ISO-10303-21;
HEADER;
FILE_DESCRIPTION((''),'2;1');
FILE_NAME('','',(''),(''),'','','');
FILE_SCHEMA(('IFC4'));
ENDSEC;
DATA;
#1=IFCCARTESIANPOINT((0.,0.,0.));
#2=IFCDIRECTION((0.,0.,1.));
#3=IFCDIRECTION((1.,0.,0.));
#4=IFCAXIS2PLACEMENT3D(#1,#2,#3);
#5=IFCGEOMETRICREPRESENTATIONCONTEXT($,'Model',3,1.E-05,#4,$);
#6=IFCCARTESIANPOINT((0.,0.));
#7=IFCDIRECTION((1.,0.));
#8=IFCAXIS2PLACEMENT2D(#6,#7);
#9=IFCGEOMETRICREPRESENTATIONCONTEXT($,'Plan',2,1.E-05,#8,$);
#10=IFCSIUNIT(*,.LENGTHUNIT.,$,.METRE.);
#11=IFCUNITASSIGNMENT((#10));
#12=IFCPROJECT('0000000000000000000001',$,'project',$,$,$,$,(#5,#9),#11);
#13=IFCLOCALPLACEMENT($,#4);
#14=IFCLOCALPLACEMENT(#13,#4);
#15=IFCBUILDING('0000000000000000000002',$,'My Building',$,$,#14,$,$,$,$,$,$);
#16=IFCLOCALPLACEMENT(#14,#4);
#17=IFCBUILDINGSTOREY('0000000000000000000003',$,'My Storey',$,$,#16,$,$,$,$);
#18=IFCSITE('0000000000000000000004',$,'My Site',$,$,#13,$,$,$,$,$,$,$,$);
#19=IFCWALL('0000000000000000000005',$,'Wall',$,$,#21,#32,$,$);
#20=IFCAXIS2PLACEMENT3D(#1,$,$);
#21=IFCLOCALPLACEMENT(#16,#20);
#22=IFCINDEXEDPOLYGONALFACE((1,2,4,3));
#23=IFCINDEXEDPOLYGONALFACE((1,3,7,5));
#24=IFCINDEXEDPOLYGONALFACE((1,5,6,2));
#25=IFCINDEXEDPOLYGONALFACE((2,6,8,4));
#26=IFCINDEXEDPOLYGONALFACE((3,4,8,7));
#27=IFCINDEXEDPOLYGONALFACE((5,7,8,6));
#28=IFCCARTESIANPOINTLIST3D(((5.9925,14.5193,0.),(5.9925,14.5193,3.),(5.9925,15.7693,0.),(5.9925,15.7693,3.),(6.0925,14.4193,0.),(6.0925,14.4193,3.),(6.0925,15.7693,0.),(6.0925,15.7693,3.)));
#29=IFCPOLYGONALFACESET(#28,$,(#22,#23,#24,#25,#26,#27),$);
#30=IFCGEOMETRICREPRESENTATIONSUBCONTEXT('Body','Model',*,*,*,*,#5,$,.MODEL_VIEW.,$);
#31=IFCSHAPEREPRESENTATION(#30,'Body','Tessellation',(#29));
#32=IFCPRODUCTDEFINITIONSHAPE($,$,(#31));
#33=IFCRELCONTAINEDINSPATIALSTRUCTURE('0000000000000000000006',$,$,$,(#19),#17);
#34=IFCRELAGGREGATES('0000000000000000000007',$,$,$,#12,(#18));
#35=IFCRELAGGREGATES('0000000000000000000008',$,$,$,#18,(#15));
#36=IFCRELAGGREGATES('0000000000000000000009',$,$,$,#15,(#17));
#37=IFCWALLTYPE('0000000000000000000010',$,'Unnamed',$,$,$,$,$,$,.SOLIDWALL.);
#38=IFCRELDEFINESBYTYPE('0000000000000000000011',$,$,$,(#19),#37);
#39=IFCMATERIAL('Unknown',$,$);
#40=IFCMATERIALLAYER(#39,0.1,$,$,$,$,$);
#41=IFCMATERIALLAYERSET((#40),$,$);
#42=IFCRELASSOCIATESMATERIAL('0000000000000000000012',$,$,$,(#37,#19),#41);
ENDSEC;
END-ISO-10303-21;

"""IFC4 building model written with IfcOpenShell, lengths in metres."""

from ifc_helpers import new_model, si_unit, frame, origin_with_axes, origin_2d_with_axis, place, context, subcontext, project, spatial, line, indexed_curve, outline, extrude, material, layer, layer_set, layer_usage, type_object, element, save


model = new_model("IFC4")

# Units and contexts
model_context = context("Model", 3, precision=1e-05, world=origin_with_axes())
plan_context = context("Plan", 2, precision=1e-05, world=origin_2d_with_axis())
body_context = subcontext(model_context, "Body", "Model", "MODEL_VIEW")
ifc_project = project(units=[si_unit("LENGTHUNIT", "METRE")], contexts=[model_context, plan_context])

# Site, building, storey
site_placement = place(None, origin_with_axes())
site = spatial("IfcSite", under=ifc_project, at=site_placement, Name="My Site")
building_placement = place(site_placement, origin_with_axes())
building = spatial("IfcBuilding", under=site, at=building_placement, Name="My Building")
storey_placement = place(building_placement, origin_with_axes())
storey = spatial("IfcBuildingStorey", under=building, at=storey_placement, Name="My Storey")

# Shared definitions
ifc_material = material(Name="Unknown")

# Wall
ifc_layer_1 = layer(ifc_material, 0.1)
ifc_layer_set_1 = layer_set([ifc_layer_1])
wall_type = type_object("IfcWallType", Name="Unnamed", PredefinedType="SOLIDWALL", material=ifc_layer_set_1)
ifc_layer_usage_1 = layer_usage(ifc_layer_set_1, "AXIS2", "POSITIVE", 0.0)
wall_1_placement = place(storey_placement, frame((6.0925, 14.5193, 0.0), z_axis=(0.0, 0.0, 1.0), x_axis=(0.0, 1.0, 0.0)))
element("IfcWall", 1, at=wall_1_placement, inside=storey, type_object=wall_type, material=ifc_layer_usage_1, Name="Wall", context=body_context, shape_type="SweptSolid", body=[
    extrude(outline(indexed_curve([(-0.1, 0.0), (0.0, 0.1), (1.25, 0.1), (1.25, 0.0)], segments=[line(1, 2, 3, 4, 1)])), origin_with_axes(), (0.0, 0.0, 1.0), 3.0),
])

save(model, "model.ifc")
